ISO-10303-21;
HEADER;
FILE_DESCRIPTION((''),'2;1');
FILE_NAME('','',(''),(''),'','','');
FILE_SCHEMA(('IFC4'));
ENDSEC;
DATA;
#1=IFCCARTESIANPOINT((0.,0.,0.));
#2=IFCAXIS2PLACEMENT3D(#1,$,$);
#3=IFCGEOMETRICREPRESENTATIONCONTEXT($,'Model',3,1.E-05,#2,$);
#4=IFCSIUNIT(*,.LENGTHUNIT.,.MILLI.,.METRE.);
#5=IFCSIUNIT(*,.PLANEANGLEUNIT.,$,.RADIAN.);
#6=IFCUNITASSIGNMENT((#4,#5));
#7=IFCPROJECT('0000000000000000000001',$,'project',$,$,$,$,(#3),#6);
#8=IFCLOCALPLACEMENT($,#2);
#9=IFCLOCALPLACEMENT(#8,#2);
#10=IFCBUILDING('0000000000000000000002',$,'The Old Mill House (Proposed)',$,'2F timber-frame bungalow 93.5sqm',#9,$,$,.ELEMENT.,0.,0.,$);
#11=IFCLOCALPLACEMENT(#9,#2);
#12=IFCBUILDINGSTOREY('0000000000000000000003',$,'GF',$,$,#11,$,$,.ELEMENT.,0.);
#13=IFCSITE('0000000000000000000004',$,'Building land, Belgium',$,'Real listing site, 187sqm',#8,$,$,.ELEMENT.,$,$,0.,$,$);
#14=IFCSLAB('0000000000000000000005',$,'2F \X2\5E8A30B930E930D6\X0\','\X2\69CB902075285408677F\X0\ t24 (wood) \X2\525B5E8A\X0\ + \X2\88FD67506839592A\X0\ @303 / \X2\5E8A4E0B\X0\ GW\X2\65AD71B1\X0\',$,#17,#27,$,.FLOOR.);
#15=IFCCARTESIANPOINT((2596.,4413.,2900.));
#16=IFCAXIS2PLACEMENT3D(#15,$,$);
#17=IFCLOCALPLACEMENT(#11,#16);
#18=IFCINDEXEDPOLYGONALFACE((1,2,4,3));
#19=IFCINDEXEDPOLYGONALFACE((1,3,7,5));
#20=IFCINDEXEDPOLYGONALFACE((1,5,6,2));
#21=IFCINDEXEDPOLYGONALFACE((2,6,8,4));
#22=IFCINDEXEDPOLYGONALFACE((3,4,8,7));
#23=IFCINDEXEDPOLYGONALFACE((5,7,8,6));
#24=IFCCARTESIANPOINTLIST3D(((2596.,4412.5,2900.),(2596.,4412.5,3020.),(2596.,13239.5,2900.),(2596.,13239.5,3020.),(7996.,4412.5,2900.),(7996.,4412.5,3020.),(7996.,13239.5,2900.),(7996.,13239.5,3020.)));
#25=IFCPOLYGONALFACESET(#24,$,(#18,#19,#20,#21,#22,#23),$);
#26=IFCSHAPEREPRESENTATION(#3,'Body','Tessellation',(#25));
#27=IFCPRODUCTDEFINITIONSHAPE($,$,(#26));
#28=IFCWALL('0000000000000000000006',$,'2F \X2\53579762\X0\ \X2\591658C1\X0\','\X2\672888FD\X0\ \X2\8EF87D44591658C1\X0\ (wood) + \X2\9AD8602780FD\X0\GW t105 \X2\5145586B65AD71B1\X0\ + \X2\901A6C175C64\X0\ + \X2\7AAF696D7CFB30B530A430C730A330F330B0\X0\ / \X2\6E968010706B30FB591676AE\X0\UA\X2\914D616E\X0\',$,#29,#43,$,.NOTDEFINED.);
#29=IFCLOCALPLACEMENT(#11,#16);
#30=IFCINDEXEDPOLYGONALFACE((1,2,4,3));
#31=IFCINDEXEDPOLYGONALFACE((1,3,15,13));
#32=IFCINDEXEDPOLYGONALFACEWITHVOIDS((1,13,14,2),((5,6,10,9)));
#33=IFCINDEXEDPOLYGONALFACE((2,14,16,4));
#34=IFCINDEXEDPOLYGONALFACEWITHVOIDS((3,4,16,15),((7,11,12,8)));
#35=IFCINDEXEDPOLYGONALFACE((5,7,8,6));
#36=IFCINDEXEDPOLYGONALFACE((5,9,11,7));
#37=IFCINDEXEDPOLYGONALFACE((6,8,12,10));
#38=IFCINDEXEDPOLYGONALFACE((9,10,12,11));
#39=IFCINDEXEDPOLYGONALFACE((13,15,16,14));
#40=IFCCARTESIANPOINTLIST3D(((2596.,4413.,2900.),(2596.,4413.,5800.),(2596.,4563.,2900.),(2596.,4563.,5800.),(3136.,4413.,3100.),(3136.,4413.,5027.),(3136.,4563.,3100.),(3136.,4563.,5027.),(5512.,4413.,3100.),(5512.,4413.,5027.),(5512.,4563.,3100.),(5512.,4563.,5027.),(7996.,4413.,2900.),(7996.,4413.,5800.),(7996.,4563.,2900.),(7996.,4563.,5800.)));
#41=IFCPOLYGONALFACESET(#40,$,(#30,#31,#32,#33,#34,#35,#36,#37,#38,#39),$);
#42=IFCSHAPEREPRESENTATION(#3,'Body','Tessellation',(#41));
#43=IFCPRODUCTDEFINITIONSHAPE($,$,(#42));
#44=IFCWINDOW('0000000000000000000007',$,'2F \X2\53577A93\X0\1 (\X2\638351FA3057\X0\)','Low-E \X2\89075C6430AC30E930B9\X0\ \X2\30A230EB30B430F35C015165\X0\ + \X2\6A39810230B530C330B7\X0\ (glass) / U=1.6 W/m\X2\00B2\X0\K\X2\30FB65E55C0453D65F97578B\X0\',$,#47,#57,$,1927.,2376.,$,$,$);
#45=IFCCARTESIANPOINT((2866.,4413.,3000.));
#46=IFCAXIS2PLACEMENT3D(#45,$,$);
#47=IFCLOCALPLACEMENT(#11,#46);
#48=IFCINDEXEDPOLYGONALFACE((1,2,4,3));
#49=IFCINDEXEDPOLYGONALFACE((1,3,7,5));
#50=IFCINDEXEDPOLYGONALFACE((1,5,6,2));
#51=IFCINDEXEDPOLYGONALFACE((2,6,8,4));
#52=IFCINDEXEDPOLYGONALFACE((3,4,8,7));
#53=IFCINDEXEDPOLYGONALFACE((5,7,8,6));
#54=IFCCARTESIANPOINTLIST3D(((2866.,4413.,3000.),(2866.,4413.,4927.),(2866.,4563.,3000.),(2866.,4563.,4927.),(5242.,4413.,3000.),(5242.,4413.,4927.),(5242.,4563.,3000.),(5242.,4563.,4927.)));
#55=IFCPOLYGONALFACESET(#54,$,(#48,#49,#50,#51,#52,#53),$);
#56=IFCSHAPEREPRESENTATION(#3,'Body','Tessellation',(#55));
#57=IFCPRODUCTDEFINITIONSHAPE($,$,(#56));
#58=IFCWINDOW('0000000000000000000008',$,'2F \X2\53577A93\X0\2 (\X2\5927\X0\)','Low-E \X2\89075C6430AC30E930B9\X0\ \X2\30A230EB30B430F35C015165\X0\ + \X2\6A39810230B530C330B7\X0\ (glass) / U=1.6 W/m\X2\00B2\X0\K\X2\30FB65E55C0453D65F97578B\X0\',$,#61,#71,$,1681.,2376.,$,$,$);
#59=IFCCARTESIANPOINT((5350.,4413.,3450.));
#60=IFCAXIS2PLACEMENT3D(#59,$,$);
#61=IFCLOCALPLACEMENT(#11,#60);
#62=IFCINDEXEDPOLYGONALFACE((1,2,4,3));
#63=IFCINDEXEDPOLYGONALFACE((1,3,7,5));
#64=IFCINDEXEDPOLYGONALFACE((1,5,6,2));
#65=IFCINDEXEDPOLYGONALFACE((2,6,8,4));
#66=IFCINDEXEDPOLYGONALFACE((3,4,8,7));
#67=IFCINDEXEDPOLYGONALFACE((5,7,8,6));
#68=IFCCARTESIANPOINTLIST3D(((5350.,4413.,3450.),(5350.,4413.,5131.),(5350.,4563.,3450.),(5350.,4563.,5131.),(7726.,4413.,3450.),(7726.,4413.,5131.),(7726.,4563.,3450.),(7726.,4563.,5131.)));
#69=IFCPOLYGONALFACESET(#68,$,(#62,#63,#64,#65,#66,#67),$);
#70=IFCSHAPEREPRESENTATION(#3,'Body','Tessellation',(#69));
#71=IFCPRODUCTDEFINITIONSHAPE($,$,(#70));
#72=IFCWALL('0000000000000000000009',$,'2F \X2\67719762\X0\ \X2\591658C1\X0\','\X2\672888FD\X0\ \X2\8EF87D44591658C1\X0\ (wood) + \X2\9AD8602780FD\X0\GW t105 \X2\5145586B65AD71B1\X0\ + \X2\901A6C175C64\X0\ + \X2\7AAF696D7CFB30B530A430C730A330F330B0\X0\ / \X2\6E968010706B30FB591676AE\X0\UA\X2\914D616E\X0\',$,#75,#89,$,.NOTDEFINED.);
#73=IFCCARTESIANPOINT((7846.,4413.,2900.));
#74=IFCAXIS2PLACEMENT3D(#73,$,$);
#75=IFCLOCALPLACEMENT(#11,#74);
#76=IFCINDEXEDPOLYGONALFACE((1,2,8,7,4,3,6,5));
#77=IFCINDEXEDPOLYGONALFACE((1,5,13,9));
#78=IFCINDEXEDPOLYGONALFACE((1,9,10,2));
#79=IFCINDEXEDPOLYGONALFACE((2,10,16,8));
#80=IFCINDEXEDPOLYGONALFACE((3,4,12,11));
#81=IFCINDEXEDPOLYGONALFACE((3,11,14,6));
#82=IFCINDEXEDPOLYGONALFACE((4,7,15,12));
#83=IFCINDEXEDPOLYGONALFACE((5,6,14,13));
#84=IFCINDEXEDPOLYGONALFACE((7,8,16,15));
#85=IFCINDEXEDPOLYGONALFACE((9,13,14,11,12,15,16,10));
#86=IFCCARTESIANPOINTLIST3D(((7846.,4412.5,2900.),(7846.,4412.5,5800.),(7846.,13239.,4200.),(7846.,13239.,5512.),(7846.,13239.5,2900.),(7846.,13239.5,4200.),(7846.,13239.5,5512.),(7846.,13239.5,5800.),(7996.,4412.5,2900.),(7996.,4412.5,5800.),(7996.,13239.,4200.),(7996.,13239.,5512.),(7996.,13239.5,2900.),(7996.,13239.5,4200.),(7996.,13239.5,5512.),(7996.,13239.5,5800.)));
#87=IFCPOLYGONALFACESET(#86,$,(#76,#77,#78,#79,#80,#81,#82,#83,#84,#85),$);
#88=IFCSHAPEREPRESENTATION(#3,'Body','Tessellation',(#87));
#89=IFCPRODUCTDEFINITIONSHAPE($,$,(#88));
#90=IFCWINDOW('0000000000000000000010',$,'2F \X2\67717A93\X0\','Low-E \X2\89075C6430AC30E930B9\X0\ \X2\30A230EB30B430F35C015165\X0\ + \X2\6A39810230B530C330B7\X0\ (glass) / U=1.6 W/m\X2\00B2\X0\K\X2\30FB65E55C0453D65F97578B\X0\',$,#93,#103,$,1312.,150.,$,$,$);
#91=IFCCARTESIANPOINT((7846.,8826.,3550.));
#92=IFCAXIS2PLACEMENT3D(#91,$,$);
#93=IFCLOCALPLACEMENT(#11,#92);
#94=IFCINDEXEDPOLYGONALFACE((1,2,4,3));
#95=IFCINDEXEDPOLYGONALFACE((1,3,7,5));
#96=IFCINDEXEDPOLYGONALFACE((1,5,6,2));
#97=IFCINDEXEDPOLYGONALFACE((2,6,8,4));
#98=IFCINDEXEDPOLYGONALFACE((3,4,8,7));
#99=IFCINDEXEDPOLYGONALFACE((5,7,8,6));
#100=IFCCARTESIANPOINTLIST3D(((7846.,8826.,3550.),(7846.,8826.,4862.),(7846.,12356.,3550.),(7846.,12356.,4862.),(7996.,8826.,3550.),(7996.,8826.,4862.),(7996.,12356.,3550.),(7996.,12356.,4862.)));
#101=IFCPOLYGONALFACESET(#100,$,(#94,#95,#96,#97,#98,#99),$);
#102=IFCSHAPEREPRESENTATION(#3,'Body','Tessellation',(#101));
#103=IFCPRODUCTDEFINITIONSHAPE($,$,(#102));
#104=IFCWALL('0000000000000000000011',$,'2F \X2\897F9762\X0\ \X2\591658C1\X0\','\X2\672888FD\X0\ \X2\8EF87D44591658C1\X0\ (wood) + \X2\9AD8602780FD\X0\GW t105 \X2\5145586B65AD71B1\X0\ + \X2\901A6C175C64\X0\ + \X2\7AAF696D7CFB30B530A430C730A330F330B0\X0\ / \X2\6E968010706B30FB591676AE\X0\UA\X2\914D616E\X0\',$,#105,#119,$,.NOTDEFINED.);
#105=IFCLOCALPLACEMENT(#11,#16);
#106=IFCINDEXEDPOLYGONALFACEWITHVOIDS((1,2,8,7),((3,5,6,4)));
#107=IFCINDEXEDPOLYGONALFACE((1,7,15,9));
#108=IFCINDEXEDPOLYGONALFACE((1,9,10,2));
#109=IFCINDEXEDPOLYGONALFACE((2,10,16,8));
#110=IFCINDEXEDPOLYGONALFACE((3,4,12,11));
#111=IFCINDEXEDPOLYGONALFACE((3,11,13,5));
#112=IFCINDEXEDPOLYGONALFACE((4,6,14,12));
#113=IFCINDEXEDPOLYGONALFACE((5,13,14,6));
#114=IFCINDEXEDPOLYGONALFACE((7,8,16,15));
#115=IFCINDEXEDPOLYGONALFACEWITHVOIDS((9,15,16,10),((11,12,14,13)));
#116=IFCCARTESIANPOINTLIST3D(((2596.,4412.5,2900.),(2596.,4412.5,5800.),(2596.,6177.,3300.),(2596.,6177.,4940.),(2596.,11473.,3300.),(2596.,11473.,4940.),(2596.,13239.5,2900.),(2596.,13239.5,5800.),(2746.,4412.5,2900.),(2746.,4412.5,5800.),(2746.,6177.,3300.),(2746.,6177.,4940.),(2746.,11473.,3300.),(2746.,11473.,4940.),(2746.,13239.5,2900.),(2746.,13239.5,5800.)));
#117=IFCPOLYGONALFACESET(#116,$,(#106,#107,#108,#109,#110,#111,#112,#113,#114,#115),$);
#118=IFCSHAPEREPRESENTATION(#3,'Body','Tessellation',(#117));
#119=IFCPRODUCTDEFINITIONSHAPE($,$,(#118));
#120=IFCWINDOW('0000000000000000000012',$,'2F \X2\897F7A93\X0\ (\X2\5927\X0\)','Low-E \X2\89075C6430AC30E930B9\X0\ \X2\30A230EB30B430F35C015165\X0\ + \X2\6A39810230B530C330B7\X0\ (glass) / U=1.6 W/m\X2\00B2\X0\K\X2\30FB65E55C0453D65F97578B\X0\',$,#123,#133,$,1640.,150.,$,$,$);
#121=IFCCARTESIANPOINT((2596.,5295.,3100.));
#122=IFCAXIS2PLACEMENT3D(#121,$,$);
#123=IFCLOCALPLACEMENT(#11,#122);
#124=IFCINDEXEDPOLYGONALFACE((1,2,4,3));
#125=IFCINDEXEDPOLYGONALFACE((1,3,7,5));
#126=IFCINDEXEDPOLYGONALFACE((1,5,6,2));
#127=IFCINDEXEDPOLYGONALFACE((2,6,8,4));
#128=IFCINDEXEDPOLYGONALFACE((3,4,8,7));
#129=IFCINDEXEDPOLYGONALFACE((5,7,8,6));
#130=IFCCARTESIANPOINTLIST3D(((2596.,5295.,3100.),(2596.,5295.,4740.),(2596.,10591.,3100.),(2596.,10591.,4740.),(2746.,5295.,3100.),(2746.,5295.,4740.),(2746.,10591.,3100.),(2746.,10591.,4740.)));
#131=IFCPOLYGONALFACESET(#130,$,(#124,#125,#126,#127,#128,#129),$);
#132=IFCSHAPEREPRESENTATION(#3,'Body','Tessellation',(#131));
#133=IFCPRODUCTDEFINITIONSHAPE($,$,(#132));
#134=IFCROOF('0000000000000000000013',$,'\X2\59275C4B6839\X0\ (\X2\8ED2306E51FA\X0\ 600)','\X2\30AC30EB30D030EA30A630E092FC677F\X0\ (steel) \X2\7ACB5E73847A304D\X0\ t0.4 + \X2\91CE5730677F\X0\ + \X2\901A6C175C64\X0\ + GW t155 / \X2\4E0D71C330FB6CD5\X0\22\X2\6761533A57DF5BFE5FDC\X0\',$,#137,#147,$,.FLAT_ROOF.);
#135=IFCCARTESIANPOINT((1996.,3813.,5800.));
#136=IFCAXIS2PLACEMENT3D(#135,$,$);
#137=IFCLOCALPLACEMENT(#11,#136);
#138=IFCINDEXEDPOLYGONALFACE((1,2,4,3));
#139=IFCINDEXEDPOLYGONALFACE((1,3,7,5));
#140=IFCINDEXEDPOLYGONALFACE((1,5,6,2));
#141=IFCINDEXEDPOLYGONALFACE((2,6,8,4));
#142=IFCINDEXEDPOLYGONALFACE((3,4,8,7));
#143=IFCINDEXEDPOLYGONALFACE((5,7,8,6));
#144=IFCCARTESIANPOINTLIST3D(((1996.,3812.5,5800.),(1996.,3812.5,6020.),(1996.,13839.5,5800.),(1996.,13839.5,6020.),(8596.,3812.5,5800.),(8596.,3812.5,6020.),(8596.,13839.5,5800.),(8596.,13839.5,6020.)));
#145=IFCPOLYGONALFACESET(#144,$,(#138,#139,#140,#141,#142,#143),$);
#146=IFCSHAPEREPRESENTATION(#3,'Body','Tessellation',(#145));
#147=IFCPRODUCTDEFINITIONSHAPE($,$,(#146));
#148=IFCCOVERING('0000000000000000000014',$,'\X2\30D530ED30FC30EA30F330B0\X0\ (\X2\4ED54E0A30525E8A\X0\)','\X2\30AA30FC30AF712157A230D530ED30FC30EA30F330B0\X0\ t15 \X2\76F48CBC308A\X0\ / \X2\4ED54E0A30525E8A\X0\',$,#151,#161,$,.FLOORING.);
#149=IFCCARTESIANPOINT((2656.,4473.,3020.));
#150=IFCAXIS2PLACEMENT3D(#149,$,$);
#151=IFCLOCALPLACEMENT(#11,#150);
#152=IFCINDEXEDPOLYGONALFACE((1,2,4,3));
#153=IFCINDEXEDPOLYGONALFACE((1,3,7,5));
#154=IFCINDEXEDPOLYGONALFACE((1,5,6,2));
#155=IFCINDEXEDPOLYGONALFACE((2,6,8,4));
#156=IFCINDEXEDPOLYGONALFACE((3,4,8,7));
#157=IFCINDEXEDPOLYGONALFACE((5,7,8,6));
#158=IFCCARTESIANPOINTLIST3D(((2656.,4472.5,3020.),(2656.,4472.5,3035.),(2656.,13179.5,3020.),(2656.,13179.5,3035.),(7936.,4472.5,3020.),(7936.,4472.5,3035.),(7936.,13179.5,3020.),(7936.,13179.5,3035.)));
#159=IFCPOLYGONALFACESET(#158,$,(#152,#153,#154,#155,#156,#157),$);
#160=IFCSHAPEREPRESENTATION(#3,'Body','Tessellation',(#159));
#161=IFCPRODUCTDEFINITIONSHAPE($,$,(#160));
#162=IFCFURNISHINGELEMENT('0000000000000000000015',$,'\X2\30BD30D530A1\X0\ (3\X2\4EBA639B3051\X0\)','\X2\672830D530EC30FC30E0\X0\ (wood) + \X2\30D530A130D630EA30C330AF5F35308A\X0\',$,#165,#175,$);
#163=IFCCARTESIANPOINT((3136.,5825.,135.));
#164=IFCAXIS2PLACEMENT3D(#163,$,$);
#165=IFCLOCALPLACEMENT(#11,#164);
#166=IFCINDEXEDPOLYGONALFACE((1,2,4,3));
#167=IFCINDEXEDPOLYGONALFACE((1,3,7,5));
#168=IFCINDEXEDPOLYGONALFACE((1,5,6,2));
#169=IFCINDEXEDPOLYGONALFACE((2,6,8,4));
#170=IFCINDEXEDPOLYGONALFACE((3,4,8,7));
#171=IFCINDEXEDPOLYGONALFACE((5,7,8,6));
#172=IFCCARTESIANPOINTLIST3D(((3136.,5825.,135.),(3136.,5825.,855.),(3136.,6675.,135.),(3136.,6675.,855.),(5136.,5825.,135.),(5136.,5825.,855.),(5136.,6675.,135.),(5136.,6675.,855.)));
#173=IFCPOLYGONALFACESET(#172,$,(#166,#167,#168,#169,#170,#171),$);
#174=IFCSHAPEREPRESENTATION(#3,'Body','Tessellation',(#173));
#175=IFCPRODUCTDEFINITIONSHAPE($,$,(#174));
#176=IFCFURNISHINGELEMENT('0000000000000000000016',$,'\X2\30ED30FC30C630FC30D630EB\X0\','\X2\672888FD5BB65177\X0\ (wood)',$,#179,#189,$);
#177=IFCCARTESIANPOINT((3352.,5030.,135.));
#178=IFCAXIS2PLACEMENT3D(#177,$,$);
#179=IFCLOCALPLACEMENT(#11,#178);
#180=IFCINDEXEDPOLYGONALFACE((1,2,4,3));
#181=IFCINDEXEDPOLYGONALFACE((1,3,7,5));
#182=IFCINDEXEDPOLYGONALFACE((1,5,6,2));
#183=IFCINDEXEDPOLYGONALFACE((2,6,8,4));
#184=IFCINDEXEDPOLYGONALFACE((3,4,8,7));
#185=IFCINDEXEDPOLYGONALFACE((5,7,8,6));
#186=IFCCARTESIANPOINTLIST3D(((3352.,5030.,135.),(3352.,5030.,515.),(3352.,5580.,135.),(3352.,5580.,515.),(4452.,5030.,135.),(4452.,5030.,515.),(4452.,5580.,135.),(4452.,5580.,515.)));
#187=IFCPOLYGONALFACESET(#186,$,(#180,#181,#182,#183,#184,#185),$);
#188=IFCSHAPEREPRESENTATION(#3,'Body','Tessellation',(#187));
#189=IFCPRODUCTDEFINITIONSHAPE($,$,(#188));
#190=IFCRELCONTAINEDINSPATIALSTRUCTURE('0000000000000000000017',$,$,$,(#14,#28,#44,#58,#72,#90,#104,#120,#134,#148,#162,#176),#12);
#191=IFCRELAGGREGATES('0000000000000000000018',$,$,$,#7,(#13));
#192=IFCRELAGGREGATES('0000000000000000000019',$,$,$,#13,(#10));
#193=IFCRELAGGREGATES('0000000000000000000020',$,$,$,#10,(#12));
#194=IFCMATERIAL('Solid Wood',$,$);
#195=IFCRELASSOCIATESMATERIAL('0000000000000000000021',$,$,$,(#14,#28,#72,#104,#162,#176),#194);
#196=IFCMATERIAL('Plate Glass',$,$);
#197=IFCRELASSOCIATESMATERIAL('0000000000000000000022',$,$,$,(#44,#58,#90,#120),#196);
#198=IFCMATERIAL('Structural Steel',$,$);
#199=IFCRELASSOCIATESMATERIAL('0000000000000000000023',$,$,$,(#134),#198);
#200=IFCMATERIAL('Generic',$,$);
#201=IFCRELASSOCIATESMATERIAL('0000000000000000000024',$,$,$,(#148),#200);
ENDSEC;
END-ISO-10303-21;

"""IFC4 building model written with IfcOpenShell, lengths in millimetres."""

from ifc_helpers import new_model, si_unit, frame, frame_2d, origin, place, context, project, spatial, rectangle, extrude, material, element, fill, save


model = new_model("IFC4")

# Units and contexts
model_context = context("Model", 3, precision=1e-05, world=origin())
ifc_project = project(units=[si_unit("LENGTHUNIT", "METRE", prefix="MILLI"), si_unit("PLANEANGLEUNIT", "RADIAN")], contexts=[model_context])

# Site, building, storey
site_placement = place(None, origin())
site = spatial("IfcSite", under=ifc_project, at=site_placement, Name="Building land, Belgium", ObjectType="Real listing site, 187sqm", CompositionType="ELEMENT", RefElevation=0.0)
building_placement = place(site_placement, origin())
building = spatial("IfcBuilding", under=site, at=building_placement, Name="The Old Mill House (Proposed)", ObjectType="2F timber-frame bungalow 93.5sqm", CompositionType="ELEMENT", ElevationOfRefHeight=0.0, ElevationOfTerrain=0.0)
storey_placement = place(building_placement, origin())
storey = spatial("IfcBuildingStorey", under=building, at=storey_placement, Name="GF", CompositionType="ELEMENT", Elevation=0.0)

# Slab
ifc_material_1 = material(Name="Solid Wood")
slab_placement = place(storey_placement, frame((2596.0, 4413.0, 2900.0)))
element("IfcSlab", 1, at=slab_placement, inside=storey, material=ifc_material_1, Name="2F 床スラブ", Description="構造用合板 t24 (wood) 剛床 + 製材根太 @303 / 床下 GW断熱", PredefinedType="FLOOR", context=model_context, shape_type="SweptSolid", body=[
    extrude(rectangle(XDim=5400.0, YDim=8827.0, at=frame_2d((2700.0, 4413.0))), frame((2596.0, 4413.0, 2900.0)), (0.0, 0.0, 1.0), 120.0),
])

# Wall, openings, windows
wall_1_placement = place(storey_placement, frame((2596.0, 4413.0, 2900.0)))
wall_1 = element("IfcWall", 2, at=wall_1_placement, inside=storey, material=ifc_material_1, Name="2F 南面 外壁", Description="木製 軸組外壁 (wood) + 高性能GW t105 充填断熱 + 通気層 + 窯業系サイディング / 準耐火・外皮UA配慮", PredefinedType="NOTDEFINED", context=model_context, shape_type="SweptSolid", body=[
    extrude(rectangle(XDim=5400.0, YDim=150.0, at=frame_2d((2700.0, 75.0))), frame((2596.0, 4413.0, 2900.0)), (0.0, 0.0, 1.0), 2900.0),
])
opening_1_placement = place(storey_placement, frame((2866.0, 4413.0, 3000.0)))
opening_1 = element("IfcOpeningElement", 3, at=opening_1_placement, cuts=wall_1, PredefinedType="NOTDEFINED", context=model_context, shape_type="SweptSolid", body=[
    extrude(rectangle(XDim=2376.0, YDim=150.0, at=frame_2d((1188.0, 75.0))), frame((2866.0, 4413.0, 3000.0)), (0.0, 0.0, 1.0), 1927.0),
])
opening_2_placement = place(storey_placement, frame((5350.0, 4413.0, 3450.0)))
opening_2 = element("IfcOpeningElement", 4, at=opening_2_placement, cuts=wall_1, PredefinedType="NOTDEFINED", context=model_context, shape_type="SweptSolid", body=[
    extrude(rectangle(XDim=2376.0, YDim=150.0, at=frame_2d((1188.0, 75.0))), frame((5350.0, 4413.0, 3450.0)), (0.0, 0.0, 1.0), 1681.0),
])
ifc_material_2 = material(Name="Plate Glass")
window_1_placement = place(storey_placement, frame((2866.0, 4413.0, 3000.0)))
window_1 = element("IfcWindow", 5, at=window_1_placement, inside=storey, material=ifc_material_2, Name="2F 南窓1 (掃出し)", Description="Low-E 複層ガラス アルゴン封入 + 樹脂サッシ (glass) / U=1.6 W/m²K・日射取得型", OverallHeight=1927.0, OverallWidth=2376.0, context=model_context, shape_type="SweptSolid", body=[
    extrude(rectangle(XDim=2376.0, YDim=150.0, at=frame_2d((1188.0, 75.0))), frame((2866.0, 4413.0, 3000.0)), (0.0, 0.0, 1.0), 1927.0),
])
fill(opening_1, window_1)
window_2_placement = place(storey_placement, frame((5350.0, 4413.0, 3450.0)))
window_2 = element("IfcWindow", 6, at=window_2_placement, inside=storey, material=ifc_material_2, Name="2F 南窓2 (大)", Description="Low-E 複層ガラス アルゴン封入 + 樹脂サッシ (glass) / U=1.6 W/m²K・日射取得型", OverallHeight=1681.0, OverallWidth=2376.0, context=model_context, shape_type="SweptSolid", body=[
    extrude(rectangle(XDim=2376.0, YDim=150.0, at=frame_2d((1188.0, 75.0))), frame((5350.0, 4413.0, 3450.0)), (0.0, 0.0, 1.0), 1681.0),
])
fill(opening_2, window_2)

# Walls, openings, windows
wall_2_placement = place(storey_placement, frame((7846.0, 4413.0, 2900.0)))
wall_2 = element("IfcWall", 7, at=wall_2_placement, inside=storey, material=ifc_material_1, Name="2F 東面 外壁", Description="木製 軸組外壁 (wood) + 高性能GW t105 充填断熱 + 通気層 + 窯業系サイディング / 準耐火・外皮UA配慮", PredefinedType="NOTDEFINED", context=model_context, shape_type="SweptSolid", body=[
    extrude(rectangle(XDim=150.0, YDim=8827.0, at=frame_2d((75.0, 4413.0))), frame((7846.0, 4413.0, 2900.0)), (0.0, 0.0, 1.0), 2900.0),
])
opening_3_placement = place(storey_placement, frame((7846.0, 8826.0, 3550.0)))
opening_3 = element("IfcOpeningElement", 8, at=opening_3_placement, cuts=wall_2, PredefinedType="NOTDEFINED", context=model_context, shape_type="SweptSolid", body=[
    extrude(rectangle(XDim=150.0, YDim=3530.0, at=frame_2d((75.0, 1765.0))), frame((7846.0, 8826.0, 3550.0)), (0.0, 0.0, 1.0), 1312.0),
])
window_3_placement = place(storey_placement, frame((7846.0, 8826.0, 3550.0)))
window_3 = element("IfcWindow", 9, at=window_3_placement, inside=storey, material=ifc_material_2, Name="2F 東窓", Description="Low-E 複層ガラス アルゴン封入 + 樹脂サッシ (glass) / U=1.6 W/m²K・日射取得型", OverallHeight=1312.0, OverallWidth=150.0, context=model_context, shape_type="SweptSolid", body=[
    extrude(rectangle(XDim=150.0, YDim=3530.0, at=frame_2d((75.0, 1765.0))), frame((7846.0, 8826.0, 3550.0)), (0.0, 0.0, 1.0), 1312.0),
])
fill(opening_3, window_3)
wall_3_placement = place(storey_placement, frame((2596.0, 4413.0, 2900.0)))
wall_3 = element("IfcWall", 10, at=wall_3_placement, inside=storey, material=ifc_material_1, Name="2F 西面 外壁", Description="木製 軸組外壁 (wood) + 高性能GW t105 充填断熱 + 通気層 + 窯業系サイディング / 準耐火・外皮UA配慮", PredefinedType="NOTDEFINED", context=model_context, shape_type="SweptSolid", body=[
    extrude(rectangle(XDim=150.0, YDim=8827.0, at=frame_2d((75.0, 4413.0))), frame((2596.0, 4413.0, 2900.0)), (0.0, 0.0, 1.0), 2900.0),
])
opening_4_placement = place(storey_placement, frame((2596.0, 5295.0, 3100.0)))
opening_4 = element("IfcOpeningElement", 11, at=opening_4_placement, cuts=wall_3, PredefinedType="NOTDEFINED", context=model_context, shape_type="SweptSolid", body=[
    extrude(rectangle(XDim=150.0, YDim=5296.0, at=frame_2d((75.0, 2648.0))), frame((2596.0, 5295.0, 3100.0)), (0.0, 0.0, 1.0), 1640.0),
])
window_4_placement = place(storey_placement, frame((2596.0, 5295.0, 3100.0)))
window_4 = element("IfcWindow", 12, at=window_4_placement, inside=storey, material=ifc_material_2, Name="2F 西窓 (大)", Description="Low-E 複層ガラス アルゴン封入 + 樹脂サッシ (glass) / U=1.6 W/m²K・日射取得型", OverallHeight=1640.0, OverallWidth=150.0, context=model_context, shape_type="SweptSolid", body=[
    extrude(rectangle(XDim=150.0, YDim=5296.0, at=frame_2d((75.0, 2648.0))), frame((2596.0, 5295.0, 3100.0)), (0.0, 0.0, 1.0), 1640.0),
])
fill(opening_4, window_4)

# Roof
ifc_material_3 = material(Name="Structural Steel")
roof_placement = place(storey_placement, frame((1996.0, 3813.0, 5800.0)))
element("IfcRoof", 13, at=roof_placement, inside=storey, material=ifc_material_3, Name="大屋根 (軒の出 600)", Description="ガルバリウム鋼板 (steel) 立平葺き t0.4 + 野地板 + 通気層 + GW t155 / 不燃・法22条区域対応", PredefinedType="FLAT_ROOF", context=model_context, shape_type="SweptSolid", body=[
    extrude(rectangle(XDim=6600.0, YDim=10027.0, at=frame_2d((3300.0, 5013.0))), frame((1996.0, 3813.0, 5800.0)), (0.0, 0.0, 1.0), 220.0),
])

# Covering
ifc_material_4 = material(Name="Generic")
covering_placement = place(storey_placement, frame((2656.0, 4473.0, 3020.0)))
element("IfcCovering", 14, at=covering_placement, inside=storey, material=ifc_material_4, Name="フローリング (仕上げ床)", Description="オーク無垢フローリング t15 直貼り / 仕上げ床", PredefinedType="FLOORING", context=model_context, shape_type="SweptSolid", body=[
    extrude(rectangle(XDim=5280.0, YDim=8707.0, at=frame_2d((2640.0, 4353.0))), frame((2656.0, 4473.0, 3020.0)), (0.0, 0.0, 1.0), 15.0),
])

# Furnishing elements
furnishing_1_placement = place(storey_placement, frame((3136.0, 5825.0, 135.0)))
element("IfcFurnishingElement", 15, at=furnishing_1_placement, inside=storey, material=ifc_material_1, Name="ソファ (3人掛け)", Description="木フレーム (wood) + ファブリック張り", context=model_context, shape_type="SweptSolid", body=[
    extrude(rectangle(XDim=2000.0, YDim=850.0, at=frame_2d((1000.0, 425.0))), frame((3136.0, 5825.0, 135.0)), (0.0, 0.0, 1.0), 720.0),
])
furnishing_2_placement = place(storey_placement, frame((3352.0, 5030.0, 135.0)))
element("IfcFurnishingElement", 16, at=furnishing_2_placement, inside=storey, material=ifc_material_1, Name="ローテーブル", Description="木製家具 (wood)", context=model_context, shape_type="SweptSolid", body=[
    extrude(rectangle(XDim=1100.0, YDim=550.0, at=frame_2d((550.0, 275.0))), frame((3352.0, 5030.0, 135.0)), (0.0, 0.0, 1.0), 380.0),
])

save(model, "model.ifc")
